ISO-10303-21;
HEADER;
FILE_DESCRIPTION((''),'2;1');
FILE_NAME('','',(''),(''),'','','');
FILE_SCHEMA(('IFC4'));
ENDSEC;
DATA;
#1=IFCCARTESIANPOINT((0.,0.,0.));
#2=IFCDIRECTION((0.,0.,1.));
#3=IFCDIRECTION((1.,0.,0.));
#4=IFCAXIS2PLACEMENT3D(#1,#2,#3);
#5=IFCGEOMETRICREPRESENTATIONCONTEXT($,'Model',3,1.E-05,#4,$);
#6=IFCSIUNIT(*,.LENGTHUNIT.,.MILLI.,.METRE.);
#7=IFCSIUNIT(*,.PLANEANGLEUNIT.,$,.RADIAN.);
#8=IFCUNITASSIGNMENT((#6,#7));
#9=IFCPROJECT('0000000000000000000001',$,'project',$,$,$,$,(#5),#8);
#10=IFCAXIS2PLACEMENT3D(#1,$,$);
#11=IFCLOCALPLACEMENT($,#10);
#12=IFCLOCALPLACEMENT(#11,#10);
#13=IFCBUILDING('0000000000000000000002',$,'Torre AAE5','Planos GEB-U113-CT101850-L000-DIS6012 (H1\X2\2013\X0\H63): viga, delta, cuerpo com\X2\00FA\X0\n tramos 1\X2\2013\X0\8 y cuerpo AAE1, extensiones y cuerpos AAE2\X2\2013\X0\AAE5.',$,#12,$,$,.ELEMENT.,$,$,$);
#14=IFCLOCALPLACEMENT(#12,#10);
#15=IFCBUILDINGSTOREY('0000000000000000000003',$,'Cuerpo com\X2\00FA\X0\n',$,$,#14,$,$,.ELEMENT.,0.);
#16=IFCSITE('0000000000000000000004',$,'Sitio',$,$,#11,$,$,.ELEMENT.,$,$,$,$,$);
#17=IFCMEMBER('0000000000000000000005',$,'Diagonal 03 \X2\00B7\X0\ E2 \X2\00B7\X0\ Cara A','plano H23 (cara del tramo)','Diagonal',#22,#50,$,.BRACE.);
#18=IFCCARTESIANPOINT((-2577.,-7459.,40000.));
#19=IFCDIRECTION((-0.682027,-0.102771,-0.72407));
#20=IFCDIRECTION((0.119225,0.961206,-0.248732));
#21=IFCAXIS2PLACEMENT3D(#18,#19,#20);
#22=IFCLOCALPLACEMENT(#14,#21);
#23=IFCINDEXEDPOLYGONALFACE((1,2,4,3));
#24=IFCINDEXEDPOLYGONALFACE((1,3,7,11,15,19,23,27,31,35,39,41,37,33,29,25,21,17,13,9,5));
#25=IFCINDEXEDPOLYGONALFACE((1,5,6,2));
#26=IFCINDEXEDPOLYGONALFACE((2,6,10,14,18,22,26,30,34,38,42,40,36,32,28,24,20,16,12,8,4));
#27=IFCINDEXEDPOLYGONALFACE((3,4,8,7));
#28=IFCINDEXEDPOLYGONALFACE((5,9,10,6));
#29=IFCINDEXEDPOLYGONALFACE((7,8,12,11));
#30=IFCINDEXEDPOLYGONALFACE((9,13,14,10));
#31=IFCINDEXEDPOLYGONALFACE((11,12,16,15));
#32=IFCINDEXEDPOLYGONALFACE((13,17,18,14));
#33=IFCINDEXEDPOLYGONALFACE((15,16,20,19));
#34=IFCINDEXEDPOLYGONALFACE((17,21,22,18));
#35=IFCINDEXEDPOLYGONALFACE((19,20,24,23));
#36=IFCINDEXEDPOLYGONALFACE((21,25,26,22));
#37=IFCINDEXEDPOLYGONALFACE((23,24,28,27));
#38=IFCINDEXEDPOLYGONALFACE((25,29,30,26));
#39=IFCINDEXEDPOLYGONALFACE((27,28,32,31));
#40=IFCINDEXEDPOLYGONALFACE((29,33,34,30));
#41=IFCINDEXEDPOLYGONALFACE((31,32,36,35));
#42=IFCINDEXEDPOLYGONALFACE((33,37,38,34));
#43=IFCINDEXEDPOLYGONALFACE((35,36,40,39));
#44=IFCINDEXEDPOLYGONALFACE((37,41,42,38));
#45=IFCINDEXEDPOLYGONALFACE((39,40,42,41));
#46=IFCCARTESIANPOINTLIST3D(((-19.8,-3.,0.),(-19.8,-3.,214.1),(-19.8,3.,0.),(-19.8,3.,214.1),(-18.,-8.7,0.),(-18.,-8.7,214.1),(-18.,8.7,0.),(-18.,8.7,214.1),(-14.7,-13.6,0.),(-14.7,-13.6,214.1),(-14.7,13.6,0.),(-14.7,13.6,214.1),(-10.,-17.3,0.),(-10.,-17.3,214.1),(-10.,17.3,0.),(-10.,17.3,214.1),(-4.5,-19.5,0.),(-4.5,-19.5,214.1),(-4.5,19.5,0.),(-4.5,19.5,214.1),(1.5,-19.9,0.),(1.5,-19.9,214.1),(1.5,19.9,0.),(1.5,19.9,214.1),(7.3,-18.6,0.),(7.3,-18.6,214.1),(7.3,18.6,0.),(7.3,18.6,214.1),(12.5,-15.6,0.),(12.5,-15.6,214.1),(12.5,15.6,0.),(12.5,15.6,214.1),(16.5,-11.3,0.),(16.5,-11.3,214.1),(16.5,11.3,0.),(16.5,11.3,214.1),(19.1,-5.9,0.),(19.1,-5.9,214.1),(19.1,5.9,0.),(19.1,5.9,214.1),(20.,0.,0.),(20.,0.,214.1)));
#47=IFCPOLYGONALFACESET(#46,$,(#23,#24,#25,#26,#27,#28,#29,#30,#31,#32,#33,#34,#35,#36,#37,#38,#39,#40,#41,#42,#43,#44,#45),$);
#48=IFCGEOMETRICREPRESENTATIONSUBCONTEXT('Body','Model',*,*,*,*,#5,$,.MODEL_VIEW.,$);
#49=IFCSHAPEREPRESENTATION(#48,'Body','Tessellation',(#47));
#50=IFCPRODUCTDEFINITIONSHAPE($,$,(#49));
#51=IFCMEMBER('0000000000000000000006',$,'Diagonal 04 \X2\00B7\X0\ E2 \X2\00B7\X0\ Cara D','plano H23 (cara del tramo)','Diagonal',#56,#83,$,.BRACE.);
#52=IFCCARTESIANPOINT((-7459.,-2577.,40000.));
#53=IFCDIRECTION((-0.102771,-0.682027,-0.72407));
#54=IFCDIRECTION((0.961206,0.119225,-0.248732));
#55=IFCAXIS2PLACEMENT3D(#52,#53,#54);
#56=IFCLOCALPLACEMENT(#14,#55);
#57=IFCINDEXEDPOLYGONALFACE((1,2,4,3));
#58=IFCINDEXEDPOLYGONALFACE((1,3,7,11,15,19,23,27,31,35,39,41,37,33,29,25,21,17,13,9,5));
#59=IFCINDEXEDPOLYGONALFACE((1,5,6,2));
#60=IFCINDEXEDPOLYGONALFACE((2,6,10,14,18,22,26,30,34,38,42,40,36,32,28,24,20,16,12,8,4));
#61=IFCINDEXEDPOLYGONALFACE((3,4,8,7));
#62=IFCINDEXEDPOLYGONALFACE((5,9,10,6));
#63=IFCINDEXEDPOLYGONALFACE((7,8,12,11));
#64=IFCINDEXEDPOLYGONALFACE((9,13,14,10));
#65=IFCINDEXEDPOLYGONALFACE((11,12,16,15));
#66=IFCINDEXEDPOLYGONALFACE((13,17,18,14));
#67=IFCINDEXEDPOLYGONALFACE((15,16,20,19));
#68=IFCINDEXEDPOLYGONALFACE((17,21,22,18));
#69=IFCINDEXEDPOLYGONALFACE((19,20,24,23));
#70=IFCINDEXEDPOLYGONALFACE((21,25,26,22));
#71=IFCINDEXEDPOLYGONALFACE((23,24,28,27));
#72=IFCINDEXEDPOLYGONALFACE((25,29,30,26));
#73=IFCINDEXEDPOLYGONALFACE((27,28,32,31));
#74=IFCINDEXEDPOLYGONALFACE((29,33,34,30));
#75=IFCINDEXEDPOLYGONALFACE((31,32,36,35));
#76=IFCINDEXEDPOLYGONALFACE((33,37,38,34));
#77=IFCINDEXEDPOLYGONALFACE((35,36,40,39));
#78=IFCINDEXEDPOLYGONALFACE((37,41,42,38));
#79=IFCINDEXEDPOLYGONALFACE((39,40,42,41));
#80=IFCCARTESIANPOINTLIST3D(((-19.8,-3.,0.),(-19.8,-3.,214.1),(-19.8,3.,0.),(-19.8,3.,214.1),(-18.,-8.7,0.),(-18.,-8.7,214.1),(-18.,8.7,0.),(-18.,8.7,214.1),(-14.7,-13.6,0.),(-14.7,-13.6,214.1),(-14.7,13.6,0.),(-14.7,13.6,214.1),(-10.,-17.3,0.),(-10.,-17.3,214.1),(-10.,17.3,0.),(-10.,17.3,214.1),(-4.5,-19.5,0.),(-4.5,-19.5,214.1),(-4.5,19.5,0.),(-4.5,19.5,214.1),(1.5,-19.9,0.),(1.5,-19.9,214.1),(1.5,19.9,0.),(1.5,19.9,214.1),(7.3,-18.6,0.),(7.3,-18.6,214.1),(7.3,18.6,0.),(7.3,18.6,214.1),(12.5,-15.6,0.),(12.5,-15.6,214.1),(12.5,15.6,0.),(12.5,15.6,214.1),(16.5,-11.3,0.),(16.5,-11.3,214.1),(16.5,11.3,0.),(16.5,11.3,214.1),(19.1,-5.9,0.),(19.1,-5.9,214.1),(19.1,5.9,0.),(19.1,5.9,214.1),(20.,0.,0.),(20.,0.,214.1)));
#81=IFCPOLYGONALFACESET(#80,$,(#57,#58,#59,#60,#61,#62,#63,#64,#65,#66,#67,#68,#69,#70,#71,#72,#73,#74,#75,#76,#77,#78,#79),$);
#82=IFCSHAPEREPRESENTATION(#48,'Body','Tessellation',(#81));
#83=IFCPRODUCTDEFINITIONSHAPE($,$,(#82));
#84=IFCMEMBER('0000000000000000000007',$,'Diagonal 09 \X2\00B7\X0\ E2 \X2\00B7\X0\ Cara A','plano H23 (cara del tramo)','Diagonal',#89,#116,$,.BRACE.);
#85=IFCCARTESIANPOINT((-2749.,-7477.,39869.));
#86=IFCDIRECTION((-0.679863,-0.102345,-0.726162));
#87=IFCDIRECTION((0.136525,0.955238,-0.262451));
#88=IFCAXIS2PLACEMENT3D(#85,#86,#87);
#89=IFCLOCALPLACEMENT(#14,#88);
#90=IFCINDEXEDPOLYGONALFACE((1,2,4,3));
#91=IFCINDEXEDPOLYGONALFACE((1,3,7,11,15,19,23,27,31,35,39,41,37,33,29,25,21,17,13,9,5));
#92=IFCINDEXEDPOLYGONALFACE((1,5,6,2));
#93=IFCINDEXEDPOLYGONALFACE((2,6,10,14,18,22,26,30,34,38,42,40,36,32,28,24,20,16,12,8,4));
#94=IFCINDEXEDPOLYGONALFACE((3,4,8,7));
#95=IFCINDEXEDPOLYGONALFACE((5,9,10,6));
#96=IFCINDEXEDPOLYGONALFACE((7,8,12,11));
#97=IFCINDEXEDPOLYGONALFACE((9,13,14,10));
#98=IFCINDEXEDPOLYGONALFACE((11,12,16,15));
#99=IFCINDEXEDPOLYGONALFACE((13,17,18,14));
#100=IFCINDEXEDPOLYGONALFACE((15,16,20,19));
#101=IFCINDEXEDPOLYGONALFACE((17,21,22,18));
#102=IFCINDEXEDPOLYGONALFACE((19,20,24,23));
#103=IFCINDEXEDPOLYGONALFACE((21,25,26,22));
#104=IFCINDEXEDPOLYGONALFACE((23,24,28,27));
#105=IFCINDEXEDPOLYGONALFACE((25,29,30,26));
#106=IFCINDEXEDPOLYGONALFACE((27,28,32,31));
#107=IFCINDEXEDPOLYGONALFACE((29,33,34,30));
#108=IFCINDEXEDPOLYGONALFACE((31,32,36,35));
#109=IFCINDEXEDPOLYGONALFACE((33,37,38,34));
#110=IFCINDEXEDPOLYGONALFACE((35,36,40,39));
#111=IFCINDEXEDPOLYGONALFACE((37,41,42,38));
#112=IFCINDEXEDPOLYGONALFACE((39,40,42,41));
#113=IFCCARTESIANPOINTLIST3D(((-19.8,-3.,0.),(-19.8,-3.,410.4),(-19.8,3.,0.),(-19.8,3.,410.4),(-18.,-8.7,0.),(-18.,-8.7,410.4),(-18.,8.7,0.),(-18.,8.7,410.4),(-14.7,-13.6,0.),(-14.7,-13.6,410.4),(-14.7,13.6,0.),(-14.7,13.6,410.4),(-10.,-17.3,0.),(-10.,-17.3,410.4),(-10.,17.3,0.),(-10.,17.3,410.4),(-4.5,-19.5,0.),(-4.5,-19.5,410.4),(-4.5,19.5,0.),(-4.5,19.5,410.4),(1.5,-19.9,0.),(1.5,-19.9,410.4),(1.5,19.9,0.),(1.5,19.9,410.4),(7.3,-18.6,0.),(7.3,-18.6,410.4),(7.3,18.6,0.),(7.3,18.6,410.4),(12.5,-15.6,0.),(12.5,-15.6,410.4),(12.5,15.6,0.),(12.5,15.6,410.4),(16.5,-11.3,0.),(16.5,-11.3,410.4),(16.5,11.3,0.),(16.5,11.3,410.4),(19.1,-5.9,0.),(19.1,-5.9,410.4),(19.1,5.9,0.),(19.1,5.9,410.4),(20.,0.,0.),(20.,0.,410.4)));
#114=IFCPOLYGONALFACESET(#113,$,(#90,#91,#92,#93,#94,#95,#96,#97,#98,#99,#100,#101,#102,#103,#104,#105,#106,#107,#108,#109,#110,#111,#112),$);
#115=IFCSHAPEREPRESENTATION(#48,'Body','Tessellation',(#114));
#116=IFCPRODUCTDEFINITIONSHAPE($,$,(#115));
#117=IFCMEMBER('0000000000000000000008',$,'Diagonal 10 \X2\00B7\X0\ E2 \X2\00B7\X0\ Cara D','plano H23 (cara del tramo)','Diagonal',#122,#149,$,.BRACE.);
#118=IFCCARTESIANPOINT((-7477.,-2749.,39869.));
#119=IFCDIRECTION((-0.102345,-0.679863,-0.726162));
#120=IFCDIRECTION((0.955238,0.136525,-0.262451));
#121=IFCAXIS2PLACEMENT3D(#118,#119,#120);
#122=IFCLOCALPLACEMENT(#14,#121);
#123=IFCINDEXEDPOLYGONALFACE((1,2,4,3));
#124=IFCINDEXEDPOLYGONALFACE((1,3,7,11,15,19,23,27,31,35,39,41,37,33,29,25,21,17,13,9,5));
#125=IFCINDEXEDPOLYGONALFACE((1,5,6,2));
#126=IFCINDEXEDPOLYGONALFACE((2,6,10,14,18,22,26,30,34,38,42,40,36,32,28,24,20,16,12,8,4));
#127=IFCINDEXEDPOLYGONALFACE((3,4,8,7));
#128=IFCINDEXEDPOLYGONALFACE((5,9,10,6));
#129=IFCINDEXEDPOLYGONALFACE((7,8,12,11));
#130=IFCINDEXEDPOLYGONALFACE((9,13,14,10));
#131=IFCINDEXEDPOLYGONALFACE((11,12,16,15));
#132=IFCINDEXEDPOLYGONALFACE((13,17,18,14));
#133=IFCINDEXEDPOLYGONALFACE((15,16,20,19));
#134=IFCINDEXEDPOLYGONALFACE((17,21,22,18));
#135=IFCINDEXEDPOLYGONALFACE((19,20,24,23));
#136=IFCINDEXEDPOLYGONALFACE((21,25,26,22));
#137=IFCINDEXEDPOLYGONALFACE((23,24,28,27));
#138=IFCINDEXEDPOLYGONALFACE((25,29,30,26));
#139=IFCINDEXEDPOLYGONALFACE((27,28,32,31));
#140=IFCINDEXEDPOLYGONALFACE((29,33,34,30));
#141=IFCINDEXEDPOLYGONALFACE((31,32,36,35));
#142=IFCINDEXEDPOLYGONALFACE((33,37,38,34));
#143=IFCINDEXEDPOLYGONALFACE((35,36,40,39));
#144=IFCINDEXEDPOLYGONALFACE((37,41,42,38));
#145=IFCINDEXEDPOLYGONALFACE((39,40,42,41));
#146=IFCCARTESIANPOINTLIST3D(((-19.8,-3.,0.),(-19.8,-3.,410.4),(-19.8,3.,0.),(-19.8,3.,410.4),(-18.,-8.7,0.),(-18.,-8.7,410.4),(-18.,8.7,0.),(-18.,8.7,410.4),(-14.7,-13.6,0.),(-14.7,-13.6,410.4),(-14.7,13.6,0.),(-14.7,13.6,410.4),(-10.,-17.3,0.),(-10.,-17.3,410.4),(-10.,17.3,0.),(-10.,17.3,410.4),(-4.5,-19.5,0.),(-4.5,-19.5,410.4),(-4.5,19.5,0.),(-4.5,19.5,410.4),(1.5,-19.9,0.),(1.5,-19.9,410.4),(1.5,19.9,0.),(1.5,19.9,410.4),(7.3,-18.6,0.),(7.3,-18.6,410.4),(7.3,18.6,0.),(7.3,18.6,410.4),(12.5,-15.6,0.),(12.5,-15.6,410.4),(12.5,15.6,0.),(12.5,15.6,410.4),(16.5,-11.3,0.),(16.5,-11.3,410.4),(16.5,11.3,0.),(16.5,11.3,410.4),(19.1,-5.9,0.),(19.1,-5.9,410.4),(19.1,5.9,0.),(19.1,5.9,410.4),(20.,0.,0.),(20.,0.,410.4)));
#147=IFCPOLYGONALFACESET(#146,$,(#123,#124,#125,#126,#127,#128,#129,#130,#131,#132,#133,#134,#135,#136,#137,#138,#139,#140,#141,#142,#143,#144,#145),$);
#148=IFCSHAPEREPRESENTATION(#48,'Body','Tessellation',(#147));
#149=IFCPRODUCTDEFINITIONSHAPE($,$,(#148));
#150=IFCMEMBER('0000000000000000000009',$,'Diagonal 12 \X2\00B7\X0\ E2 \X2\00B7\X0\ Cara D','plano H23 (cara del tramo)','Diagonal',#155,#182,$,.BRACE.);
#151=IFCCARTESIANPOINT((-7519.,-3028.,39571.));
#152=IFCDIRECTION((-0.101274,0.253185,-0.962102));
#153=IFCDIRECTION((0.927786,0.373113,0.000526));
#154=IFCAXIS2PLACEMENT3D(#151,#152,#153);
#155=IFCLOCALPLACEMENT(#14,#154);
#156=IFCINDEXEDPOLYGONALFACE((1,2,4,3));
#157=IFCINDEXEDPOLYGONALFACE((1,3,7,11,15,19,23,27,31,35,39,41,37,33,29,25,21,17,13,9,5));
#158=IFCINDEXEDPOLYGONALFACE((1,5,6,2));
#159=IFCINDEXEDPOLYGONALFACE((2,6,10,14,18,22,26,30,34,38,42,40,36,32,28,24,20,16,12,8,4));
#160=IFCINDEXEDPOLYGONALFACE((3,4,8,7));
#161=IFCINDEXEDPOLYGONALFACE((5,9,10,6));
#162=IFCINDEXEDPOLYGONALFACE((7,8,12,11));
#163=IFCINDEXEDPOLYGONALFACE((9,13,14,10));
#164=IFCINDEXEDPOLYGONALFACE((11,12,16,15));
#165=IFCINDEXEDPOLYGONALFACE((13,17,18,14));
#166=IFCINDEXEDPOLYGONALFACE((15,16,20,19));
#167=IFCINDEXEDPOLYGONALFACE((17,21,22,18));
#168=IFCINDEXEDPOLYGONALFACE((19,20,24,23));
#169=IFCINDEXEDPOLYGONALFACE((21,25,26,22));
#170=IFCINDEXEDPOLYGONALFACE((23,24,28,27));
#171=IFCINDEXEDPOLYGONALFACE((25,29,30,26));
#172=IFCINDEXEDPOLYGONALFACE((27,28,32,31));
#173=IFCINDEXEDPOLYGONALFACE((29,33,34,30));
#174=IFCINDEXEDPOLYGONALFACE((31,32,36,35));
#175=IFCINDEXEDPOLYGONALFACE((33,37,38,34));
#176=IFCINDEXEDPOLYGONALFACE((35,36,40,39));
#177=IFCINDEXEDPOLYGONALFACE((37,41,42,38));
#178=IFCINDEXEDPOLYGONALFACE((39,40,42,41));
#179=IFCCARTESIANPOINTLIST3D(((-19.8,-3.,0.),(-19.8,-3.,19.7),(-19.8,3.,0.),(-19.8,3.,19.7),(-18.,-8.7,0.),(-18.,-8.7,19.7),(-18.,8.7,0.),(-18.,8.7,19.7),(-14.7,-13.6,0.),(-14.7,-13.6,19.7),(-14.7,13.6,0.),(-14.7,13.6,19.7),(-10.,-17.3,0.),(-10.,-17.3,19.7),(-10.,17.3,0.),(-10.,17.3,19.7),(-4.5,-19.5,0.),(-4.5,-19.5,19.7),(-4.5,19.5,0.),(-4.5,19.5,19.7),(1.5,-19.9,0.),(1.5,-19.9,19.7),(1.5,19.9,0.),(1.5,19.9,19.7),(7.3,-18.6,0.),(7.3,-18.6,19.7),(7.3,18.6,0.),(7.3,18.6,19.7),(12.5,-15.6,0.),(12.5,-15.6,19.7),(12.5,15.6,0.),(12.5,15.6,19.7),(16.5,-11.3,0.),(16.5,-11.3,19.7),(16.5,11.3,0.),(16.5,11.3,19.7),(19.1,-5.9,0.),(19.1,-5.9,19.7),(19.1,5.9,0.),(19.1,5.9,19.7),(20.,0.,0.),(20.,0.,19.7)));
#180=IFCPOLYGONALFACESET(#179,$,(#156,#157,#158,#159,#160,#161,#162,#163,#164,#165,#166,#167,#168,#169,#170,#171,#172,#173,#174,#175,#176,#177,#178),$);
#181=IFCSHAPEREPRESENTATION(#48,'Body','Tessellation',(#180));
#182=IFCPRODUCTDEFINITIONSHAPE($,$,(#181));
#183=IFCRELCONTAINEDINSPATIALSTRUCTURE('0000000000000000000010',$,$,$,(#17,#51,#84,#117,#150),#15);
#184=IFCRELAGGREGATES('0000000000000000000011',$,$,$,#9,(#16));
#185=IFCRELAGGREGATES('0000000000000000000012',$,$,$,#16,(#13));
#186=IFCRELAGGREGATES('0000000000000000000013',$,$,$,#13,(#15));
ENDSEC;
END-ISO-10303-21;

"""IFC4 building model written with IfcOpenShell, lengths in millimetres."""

from ifc_helpers import new_model, si_unit, frame, origin, origin_with_axes, place, context, subcontext, project, spatial, circle, extrude, element, save


model = new_model("IFC4")

# Units and contexts
model_context = context("Model", 3, precision=1e-05, world=origin_with_axes())
body_context = subcontext(model_context, "Body", "Model", "MODEL_VIEW")
ifc_project = project(units=[si_unit("LENGTHUNIT", "METRE", prefix="MILLI"), si_unit("PLANEANGLEUNIT", "RADIAN")], contexts=[model_context])

# Site, building, storey
site_placement = place(None, origin())
site = spatial("IfcSite", under=ifc_project, at=site_placement, Name="Sitio", CompositionType="ELEMENT")
building_placement = place(site_placement, origin())
building = spatial("IfcBuilding", under=site, at=building_placement, Name="Torre AAE5", Description="Planos GEB-U113-CT101850-L000-DIS6012 (H1–H63): viga, delta, cuerpo común tramos 1–8 y cuerpo AAE1, extensiones y cuerpos AAE2–AAE5.", CompositionType="ELEMENT")
storey_placement = place(building_placement, origin())
storey = spatial("IfcBuildingStorey", under=building, at=storey_placement, Name="Cuerpo común", CompositionType="ELEMENT", Elevation=0.0)

# Members
for number, where, z_axis, x_axis, name in (
    (1, (-2577.0, -7459.0, 40000.0), (-0.682027, -0.102771, -0.72407), (0.119225, 0.961206, -0.248732), "Diagonal 03 · E2 · Cara A"),
    (2, (-7459.0, -2577.0, 40000.0), (-0.102771, -0.682027, -0.72407), (0.961206, 0.119225, -0.248732), "Diagonal 04 · E2 · Cara D"),
):
    element("IfcMember", number, at=place(storey_placement, frame(where, z_axis=z_axis, x_axis=x_axis)), inside=storey, Name=name, Description="plano H23 (cara del tramo)", ObjectType="Diagonal", PredefinedType="BRACE", context=body_context, shape_type="SweptSolid", body=[
        extrude(circle(Radius=20.0), None, (0.0, 0.0, 1.0), 214.1),
    ])
for number, where, z_axis, x_axis, name in (
    (3, (-2749.0, -7477.0, 39869.0), (-0.679863, -0.102345, -0.726162), (0.136525, 0.955238, -0.262451), "Diagonal 09 · E2 · Cara A"),
    (4, (-7477.0, -2749.0, 39869.0), (-0.102345, -0.679863, -0.726162), (0.955238, 0.136525, -0.262451), "Diagonal 10 · E2 · Cara D"),
):
    element("IfcMember", number, at=place(storey_placement, frame(where, z_axis=z_axis, x_axis=x_axis)), inside=storey, Name=name, Description="plano H23 (cara del tramo)", ObjectType="Diagonal", PredefinedType="BRACE", context=body_context, shape_type="SweptSolid", body=[
        extrude(circle(Radius=20.0), None, (0.0, 0.0, 1.0), 410.4),
    ])
member_1_placement = place(storey_placement, frame((-7519.0, -3028.0, 39571.0), z_axis=(-0.101274, 0.253185, -0.962102), x_axis=(0.927786, 0.373113, 0.000526)))
element("IfcMember", 5, at=member_1_placement, inside=storey, Name="Diagonal 12 · E2 · Cara D", Description="plano H23 (cara del tramo)", ObjectType="Diagonal", PredefinedType="BRACE", context=body_context, shape_type="SweptSolid", body=[
    extrude(circle(Radius=20.0), None, (0.0, 0.0, 1.0), 19.7),
])

save(model, "model.ifc")
